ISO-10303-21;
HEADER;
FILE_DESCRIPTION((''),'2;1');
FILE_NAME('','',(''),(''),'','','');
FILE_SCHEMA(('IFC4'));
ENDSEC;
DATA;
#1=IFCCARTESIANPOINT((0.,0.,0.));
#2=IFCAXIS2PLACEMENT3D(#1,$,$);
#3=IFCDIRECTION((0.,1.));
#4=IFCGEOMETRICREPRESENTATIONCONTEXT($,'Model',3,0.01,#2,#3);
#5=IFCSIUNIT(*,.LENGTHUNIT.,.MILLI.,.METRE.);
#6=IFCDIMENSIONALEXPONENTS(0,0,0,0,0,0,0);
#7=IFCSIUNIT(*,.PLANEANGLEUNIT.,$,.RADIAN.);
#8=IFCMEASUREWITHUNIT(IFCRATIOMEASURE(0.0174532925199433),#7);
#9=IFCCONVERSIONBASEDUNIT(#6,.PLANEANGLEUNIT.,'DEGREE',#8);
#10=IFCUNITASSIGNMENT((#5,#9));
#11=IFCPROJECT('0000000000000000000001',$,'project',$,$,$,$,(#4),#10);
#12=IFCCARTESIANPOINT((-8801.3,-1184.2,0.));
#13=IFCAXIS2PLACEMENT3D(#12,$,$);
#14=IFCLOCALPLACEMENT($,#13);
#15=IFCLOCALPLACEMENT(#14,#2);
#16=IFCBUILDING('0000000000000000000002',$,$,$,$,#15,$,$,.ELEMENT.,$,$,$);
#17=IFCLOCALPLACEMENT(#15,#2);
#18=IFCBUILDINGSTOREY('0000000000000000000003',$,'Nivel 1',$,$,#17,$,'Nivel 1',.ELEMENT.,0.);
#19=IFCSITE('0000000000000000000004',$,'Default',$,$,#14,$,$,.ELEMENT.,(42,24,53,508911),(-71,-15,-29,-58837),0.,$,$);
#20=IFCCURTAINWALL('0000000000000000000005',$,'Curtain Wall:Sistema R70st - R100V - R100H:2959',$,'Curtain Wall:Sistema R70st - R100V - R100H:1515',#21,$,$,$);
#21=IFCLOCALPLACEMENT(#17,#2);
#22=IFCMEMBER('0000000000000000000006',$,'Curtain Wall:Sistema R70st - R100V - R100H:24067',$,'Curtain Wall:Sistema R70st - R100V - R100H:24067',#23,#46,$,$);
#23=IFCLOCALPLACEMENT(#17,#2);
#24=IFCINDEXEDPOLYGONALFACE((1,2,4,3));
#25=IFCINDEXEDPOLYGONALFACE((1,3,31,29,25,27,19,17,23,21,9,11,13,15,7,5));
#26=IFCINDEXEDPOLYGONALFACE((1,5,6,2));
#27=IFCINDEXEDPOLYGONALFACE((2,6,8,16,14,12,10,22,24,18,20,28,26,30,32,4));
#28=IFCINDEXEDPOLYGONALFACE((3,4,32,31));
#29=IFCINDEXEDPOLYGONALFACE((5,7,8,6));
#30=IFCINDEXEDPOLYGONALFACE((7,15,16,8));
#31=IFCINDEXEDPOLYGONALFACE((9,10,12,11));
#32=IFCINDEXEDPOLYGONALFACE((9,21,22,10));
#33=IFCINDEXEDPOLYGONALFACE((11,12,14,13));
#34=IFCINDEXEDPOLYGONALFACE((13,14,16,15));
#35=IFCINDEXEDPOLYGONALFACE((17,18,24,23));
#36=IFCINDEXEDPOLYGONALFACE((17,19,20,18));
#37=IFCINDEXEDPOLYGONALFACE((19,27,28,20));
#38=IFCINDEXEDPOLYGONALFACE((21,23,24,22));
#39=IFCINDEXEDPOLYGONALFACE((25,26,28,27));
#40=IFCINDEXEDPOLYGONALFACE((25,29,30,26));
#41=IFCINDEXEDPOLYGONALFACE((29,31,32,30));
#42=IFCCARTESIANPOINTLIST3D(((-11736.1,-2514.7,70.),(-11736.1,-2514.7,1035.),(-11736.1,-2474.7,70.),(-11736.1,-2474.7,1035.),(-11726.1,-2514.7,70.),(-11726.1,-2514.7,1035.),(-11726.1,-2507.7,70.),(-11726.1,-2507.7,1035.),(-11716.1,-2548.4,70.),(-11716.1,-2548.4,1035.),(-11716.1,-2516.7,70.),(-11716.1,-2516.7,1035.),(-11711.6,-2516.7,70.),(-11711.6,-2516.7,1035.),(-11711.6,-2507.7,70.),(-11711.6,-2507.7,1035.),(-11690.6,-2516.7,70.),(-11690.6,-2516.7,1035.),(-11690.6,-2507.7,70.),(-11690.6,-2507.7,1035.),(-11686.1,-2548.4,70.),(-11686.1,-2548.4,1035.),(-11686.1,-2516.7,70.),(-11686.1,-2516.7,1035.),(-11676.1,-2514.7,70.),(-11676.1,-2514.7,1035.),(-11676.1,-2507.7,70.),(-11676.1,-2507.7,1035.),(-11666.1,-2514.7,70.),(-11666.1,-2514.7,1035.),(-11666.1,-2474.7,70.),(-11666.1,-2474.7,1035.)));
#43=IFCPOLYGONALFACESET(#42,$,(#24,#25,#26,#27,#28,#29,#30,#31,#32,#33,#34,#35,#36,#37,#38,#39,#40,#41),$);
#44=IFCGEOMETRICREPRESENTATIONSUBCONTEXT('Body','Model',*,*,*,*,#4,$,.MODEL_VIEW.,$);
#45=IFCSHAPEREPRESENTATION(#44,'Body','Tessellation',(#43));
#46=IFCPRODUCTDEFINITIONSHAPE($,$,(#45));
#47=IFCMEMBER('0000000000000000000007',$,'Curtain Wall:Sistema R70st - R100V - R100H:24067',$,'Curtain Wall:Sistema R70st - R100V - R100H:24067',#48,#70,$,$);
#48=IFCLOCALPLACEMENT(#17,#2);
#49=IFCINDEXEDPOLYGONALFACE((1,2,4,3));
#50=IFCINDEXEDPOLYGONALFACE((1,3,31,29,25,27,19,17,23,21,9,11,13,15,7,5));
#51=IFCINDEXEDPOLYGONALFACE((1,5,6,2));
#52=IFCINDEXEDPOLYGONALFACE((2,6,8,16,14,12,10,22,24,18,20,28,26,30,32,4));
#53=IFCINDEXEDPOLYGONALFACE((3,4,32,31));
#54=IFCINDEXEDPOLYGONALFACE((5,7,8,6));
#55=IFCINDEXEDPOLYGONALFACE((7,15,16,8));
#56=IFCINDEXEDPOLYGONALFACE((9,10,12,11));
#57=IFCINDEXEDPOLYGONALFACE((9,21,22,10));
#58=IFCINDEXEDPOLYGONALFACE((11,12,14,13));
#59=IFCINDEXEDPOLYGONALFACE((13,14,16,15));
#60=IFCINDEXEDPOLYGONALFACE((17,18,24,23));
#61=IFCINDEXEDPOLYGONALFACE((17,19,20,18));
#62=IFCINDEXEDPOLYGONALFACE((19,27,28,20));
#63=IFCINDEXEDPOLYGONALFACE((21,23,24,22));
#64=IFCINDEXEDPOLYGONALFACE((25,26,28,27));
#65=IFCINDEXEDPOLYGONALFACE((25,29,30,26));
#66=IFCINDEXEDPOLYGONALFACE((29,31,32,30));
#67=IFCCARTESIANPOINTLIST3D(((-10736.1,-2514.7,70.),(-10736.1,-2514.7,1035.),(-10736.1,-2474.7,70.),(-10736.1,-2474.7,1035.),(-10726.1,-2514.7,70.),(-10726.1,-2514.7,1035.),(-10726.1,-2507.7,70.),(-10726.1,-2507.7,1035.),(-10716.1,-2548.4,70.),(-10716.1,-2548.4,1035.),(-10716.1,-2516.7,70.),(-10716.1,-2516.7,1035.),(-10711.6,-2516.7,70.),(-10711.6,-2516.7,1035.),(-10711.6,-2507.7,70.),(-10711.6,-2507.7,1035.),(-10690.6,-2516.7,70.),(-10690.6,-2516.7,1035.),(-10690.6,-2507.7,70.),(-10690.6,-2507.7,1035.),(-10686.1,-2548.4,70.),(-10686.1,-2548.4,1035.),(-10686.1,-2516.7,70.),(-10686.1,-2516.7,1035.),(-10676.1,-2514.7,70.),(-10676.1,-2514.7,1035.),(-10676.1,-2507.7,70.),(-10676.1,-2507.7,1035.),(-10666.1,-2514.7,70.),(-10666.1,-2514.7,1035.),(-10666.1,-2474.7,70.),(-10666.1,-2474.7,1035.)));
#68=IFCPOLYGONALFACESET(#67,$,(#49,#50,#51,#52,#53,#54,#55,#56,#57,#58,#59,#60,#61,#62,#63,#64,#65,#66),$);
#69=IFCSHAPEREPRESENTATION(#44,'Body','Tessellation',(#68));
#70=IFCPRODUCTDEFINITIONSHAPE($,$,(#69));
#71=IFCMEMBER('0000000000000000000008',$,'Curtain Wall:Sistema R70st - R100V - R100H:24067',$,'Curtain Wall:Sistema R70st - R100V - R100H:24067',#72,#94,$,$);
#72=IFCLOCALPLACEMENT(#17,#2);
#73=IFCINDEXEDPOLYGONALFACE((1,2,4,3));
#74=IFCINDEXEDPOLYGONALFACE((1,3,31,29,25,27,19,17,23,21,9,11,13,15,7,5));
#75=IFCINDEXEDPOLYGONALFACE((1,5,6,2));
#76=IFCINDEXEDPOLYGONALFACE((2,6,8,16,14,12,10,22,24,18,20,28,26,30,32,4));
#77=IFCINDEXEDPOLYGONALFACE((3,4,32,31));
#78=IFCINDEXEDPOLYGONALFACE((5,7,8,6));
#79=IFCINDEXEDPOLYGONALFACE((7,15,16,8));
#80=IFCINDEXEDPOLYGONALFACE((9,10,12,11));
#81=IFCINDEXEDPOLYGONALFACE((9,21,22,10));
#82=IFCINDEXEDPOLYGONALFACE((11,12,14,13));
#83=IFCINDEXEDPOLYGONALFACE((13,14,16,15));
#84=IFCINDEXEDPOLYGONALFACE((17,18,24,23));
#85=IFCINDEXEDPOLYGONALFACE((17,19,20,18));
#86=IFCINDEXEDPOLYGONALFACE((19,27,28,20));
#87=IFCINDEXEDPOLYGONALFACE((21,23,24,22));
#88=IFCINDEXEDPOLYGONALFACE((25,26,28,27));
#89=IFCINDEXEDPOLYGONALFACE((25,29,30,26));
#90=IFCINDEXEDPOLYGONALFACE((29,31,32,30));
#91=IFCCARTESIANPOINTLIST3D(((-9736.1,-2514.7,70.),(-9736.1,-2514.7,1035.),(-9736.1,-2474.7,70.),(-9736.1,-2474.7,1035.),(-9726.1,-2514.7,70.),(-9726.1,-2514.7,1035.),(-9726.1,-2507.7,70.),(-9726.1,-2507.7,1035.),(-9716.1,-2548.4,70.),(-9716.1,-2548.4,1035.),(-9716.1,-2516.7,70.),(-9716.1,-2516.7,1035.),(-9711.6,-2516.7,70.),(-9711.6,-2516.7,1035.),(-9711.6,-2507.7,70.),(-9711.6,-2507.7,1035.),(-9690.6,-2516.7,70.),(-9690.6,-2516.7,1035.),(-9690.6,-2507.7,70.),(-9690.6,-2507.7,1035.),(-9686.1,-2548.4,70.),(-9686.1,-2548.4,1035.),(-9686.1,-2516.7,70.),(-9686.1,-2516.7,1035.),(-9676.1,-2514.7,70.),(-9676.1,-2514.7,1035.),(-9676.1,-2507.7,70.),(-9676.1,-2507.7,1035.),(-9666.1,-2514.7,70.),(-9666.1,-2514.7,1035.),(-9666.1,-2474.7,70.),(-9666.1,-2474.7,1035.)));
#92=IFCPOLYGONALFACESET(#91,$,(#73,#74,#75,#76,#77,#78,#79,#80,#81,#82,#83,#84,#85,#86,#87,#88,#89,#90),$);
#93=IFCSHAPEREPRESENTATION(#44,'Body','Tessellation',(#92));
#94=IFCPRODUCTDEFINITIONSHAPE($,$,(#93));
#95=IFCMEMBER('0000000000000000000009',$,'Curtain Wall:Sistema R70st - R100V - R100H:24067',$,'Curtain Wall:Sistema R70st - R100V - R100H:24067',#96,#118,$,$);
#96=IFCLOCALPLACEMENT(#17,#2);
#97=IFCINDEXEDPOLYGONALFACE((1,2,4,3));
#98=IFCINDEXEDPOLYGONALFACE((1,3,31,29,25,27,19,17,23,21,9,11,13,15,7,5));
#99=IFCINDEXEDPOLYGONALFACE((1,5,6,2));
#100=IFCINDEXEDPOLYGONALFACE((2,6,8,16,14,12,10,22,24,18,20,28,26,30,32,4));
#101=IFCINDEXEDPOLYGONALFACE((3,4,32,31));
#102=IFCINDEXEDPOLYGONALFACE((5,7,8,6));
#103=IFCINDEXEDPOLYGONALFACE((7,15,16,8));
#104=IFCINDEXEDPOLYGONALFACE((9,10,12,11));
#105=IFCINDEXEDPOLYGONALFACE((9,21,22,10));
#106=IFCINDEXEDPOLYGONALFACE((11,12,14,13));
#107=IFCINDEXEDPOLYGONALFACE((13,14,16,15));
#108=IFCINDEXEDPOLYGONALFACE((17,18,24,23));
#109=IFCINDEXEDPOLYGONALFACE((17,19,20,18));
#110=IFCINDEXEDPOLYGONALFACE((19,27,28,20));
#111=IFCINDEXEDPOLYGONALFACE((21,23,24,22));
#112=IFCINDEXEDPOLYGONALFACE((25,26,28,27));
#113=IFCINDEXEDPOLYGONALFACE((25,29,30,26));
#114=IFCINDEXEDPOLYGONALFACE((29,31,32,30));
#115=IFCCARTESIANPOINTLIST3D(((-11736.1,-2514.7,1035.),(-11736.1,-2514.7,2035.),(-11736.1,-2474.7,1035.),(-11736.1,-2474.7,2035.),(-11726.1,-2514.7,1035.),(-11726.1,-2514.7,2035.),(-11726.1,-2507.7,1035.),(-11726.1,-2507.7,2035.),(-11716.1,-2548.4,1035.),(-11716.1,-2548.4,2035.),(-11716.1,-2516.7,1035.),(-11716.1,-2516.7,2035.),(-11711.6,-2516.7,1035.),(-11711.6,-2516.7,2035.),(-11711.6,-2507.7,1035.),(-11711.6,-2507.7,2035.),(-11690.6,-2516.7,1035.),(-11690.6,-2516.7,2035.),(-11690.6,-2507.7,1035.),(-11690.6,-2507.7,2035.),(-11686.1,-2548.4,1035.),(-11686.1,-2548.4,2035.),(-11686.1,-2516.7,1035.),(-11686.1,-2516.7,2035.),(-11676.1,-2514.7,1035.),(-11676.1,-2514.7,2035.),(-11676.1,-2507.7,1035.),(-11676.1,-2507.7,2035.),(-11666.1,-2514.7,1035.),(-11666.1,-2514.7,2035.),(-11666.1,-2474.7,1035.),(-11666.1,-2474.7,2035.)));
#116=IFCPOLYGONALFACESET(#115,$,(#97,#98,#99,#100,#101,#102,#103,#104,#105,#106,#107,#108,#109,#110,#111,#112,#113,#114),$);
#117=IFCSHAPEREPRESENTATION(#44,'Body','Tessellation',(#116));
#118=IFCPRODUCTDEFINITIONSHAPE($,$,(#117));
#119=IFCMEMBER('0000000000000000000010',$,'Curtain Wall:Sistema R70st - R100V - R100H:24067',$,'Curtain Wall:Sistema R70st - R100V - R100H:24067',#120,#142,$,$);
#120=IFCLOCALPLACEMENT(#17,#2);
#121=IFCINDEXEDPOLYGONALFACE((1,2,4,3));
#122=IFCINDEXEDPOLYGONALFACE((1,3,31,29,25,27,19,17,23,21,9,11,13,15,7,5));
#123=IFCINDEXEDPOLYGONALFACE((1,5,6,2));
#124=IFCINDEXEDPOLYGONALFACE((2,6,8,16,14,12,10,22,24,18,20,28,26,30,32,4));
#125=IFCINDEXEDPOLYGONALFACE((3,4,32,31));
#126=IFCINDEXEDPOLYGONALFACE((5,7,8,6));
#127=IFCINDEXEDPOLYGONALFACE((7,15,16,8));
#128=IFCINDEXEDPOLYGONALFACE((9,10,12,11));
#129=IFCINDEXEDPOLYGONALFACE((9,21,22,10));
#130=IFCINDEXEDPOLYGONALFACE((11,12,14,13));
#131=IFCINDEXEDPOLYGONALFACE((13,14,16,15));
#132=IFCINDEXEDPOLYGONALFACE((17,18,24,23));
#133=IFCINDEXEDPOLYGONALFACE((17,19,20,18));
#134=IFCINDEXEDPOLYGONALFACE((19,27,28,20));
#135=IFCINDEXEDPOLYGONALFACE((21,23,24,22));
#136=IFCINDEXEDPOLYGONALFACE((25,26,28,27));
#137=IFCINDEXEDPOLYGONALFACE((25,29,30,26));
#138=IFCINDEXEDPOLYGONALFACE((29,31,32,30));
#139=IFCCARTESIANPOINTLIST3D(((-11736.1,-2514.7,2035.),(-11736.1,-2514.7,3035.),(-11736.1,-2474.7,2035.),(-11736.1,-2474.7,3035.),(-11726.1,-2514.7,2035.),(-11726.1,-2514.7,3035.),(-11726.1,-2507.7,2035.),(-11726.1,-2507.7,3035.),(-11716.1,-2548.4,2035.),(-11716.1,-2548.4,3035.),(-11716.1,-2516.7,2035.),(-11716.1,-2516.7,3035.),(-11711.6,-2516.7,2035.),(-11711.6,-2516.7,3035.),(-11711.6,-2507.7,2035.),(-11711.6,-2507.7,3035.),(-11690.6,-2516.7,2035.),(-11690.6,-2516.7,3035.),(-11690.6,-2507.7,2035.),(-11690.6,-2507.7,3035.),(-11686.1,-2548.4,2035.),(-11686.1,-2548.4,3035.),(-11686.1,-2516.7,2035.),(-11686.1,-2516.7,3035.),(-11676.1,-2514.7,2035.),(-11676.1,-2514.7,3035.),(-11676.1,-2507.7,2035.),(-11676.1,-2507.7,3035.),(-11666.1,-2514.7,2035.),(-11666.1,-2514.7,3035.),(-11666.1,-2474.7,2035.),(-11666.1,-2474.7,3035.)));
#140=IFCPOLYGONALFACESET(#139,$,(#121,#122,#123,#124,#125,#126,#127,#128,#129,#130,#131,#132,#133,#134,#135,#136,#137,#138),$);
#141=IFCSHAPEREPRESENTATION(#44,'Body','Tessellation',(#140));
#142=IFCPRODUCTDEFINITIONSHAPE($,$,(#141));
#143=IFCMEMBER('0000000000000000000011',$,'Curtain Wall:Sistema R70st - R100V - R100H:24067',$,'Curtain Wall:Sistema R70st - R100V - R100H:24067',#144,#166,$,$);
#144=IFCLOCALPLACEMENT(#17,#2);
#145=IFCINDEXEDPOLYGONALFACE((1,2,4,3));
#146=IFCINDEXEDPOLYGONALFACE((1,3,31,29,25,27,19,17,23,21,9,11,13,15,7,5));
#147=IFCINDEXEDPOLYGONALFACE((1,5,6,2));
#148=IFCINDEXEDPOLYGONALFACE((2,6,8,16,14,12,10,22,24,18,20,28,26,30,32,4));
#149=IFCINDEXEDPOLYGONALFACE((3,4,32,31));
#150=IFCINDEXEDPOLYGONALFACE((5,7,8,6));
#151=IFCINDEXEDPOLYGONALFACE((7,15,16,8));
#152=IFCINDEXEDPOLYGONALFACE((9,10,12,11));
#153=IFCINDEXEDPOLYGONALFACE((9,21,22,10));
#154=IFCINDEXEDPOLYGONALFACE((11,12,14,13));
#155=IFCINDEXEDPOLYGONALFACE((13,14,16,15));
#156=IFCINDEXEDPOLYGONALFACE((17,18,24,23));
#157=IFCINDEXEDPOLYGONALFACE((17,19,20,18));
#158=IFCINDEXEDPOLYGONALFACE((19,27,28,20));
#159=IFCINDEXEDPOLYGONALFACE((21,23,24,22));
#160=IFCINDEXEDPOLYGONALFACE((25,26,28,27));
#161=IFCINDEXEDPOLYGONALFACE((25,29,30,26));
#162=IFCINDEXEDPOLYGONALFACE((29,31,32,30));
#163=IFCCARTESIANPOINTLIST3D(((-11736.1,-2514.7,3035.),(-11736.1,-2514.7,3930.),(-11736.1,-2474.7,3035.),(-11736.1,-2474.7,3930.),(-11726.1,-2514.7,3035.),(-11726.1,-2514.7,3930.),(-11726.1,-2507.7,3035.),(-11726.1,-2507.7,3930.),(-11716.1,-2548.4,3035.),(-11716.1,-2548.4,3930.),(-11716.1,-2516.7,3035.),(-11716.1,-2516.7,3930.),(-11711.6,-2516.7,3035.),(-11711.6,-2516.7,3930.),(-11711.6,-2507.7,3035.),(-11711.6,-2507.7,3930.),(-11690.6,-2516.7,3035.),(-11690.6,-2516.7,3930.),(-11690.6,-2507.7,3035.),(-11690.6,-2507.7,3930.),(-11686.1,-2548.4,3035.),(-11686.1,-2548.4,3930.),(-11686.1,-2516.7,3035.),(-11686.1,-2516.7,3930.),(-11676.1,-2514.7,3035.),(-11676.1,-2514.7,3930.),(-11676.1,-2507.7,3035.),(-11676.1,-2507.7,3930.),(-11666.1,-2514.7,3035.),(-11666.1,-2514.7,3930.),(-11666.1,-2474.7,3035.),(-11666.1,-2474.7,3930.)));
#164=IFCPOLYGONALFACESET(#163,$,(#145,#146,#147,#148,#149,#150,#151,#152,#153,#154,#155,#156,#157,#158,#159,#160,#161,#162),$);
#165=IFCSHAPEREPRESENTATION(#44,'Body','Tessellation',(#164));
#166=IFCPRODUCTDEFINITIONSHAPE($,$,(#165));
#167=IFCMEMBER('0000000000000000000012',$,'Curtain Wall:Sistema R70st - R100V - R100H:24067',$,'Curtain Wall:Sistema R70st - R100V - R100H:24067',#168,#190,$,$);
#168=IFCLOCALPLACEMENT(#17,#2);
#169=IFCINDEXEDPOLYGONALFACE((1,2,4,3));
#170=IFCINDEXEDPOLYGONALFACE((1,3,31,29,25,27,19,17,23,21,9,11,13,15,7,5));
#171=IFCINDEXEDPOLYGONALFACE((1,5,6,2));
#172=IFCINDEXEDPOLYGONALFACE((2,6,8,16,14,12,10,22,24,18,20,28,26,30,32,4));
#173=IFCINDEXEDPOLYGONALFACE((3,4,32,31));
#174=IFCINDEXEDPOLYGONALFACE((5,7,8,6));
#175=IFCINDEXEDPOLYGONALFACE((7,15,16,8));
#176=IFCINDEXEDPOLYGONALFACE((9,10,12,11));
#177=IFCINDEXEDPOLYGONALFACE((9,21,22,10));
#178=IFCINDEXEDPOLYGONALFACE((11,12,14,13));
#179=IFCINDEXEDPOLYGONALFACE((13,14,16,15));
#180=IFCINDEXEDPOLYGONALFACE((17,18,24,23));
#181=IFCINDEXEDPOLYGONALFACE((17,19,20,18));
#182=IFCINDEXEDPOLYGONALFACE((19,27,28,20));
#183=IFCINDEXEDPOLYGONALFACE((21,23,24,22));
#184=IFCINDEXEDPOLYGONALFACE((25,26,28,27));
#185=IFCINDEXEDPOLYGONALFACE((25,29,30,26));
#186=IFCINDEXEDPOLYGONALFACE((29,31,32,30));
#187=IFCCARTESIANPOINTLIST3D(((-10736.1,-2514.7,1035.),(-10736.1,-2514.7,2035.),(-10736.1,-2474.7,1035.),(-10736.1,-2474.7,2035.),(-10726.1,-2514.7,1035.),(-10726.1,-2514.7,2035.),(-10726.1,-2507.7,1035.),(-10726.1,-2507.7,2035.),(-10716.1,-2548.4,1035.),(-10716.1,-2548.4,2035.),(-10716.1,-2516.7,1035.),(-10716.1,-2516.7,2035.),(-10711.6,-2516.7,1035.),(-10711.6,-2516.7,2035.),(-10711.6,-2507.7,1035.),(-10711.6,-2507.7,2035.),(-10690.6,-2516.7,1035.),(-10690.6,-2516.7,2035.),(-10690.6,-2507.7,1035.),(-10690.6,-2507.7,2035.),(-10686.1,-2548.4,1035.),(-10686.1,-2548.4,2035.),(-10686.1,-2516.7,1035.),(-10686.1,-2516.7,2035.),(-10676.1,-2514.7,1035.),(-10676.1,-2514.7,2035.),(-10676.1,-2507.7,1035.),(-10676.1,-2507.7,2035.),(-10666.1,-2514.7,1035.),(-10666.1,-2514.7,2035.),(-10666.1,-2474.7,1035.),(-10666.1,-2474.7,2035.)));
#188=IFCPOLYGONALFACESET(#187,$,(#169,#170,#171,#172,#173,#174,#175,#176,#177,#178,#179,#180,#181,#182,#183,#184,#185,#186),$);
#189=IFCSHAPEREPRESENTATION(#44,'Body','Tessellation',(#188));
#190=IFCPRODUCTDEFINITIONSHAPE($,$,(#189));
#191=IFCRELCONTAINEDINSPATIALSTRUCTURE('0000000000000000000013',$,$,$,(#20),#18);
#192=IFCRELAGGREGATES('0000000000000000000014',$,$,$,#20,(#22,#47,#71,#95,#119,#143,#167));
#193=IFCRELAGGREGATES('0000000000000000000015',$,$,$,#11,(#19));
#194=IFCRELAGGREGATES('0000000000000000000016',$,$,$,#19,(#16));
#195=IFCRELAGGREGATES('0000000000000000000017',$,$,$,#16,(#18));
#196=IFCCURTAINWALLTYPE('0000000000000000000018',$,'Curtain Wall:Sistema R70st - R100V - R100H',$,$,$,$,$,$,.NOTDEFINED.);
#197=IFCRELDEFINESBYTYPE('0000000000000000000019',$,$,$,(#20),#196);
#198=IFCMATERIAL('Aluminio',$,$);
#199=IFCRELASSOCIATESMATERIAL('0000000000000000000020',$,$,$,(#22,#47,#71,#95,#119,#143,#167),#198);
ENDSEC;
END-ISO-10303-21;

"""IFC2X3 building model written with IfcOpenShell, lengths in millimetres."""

from ifc_helpers import new_model, entity, si_unit, converted_unit, direction, frame, origin, place, context, subcontext, project, spatial, polyline, outline, extrude, material, type_object, element, aggregate, save


model = new_model("IFC2X3")

# Units and contexts
model_context = context("Model", 3, precision=0.01, world=origin(), true_north=direction((0.0, 1.0)))
body_context = subcontext(model_context, "Body", "Model", "MODEL_VIEW")
ifc_project = project(units=[si_unit("LENGTHUNIT", "METRE", prefix="MILLI"), converted_unit("PLANEANGLEUNIT", "DEGREE", entity("IfcRatioMeasure", 0.0174532925199433), si_unit("PLANEANGLEUNIT", "RADIAN"), dimensions=[0, 0, 0, 0, 0, 0, 0])], contexts=[model_context])

# Site, building, storey
site_placement = place(None, frame((-8801.3, -1184.2, 0.0)))
site = spatial("IfcSite", under=ifc_project, at=site_placement, Name="Default", CompositionType="ELEMENT", RefLatitude=(42, 24, 53, 508911), RefLongitude=(-71, -15, -29, -58837), RefElevation=0.0)
building_placement = place(site_placement, origin())
building = spatial("IfcBuilding", under=site, at=building_placement, CompositionType="ELEMENT")
storey_placement = place(building_placement, origin())
storey = spatial("IfcBuildingStorey", under=building, at=storey_placement, Name="Nivel 1", LongName="Nivel 1", CompositionType="ELEMENT", Elevation=0.0)

# Curtain wall, members
curtain_wall_type = type_object("IfcCurtainWallType", Name="Curtain Wall:Sistema R70st - R100V - R100H", PredefinedType="NOTDEFINED")
curtain_wall_placement = place(storey_placement, origin())
curtain_wall = element("IfcCurtainWall", 1, at=curtain_wall_placement, inside=storey, type_object=curtain_wall_type, Name="Curtain Wall:Sistema R70st - R100V - R100H:2959", ObjectType="Curtain Wall:Sistema R70st - R100V - R100H:1515")
ifc_material = material(Name="Aluminio")
member_1_placement = place(curtain_wall_placement, origin())
member_1 = element("IfcMember", 2, at=member_1_placement, material=ifc_material, Name="Curtain Wall:Sistema R70st - R100V - R100H:24067", ObjectType="Curtain Wall:Sistema R70st - R100V - R100H:24067", context=body_context, shape_type="SweptSolid", body=[
    extrude(outline(polyline([(-35.0, -38.0), (35.0, -38.0), (35.0, 2.0), (25.0, 2.0), (25.0, -5.0), (10.5, -5.0), (10.5, 4.0), (15.0, 4.0), (15.0, 35.7), (-15.0, 35.7), (-15.0, 4.0), (-10.5, 4.0), (-10.5, -5.0), (-25.0, -5.0), (-25.0, 2.0), (-35.0, 2.0), (-35.0, -38.0)])), frame((-11701.1, -2512.7, 70.0), z_axis=(0.0, 0.0, 1.0), x_axis=(-1.0, 0.0, 0.0)), (0.0, 0.0, 1.0), 965.0),
])
member_2_placement = place(curtain_wall_placement, origin())
member_2 = element("IfcMember", 3, at=member_2_placement, material=ifc_material, Name="Curtain Wall:Sistema R70st - R100V - R100H:24067", ObjectType="Curtain Wall:Sistema R70st - R100V - R100H:24067", context=body_context, shape_type="SweptSolid", body=[
    extrude(outline(polyline([(-35.0, -38.0), (35.0, -38.0), (35.0, 2.0), (25.0, 2.0), (25.0, -5.0), (10.5, -5.0), (10.5, 4.0), (15.0, 4.0), (15.0, 35.7), (-15.0, 35.7), (-15.0, 4.0), (-10.5, 4.0), (-10.5, -5.0), (-25.0, -5.0), (-25.0, 2.0), (-35.0, 2.0), (-35.0, -38.0)])), frame((-10701.1, -2512.7, 70.0), z_axis=(0.0, 0.0, 1.0), x_axis=(-1.0, 0.0, 0.0)), (0.0, 0.0, 1.0), 965.0),
])
member_3_placement = place(curtain_wall_placement, origin())
member_3 = element("IfcMember", 4, at=member_3_placement, material=ifc_material, Name="Curtain Wall:Sistema R70st - R100V - R100H:24067", ObjectType="Curtain Wall:Sistema R70st - R100V - R100H:24067", context=body_context, shape_type="SweptSolid", body=[
    extrude(outline(polyline([(-35.0, -38.0), (35.0, -38.0), (35.0, 2.0), (25.0, 2.0), (25.0, -5.0), (10.5, -5.0), (10.5, 4.0), (15.0, 4.0), (15.0, 35.7), (-15.0, 35.7), (-15.0, 4.0), (-10.5, 4.0), (-10.5, -5.0), (-25.0, -5.0), (-25.0, 2.0), (-35.0, 2.0), (-35.0, -38.0)])), frame((-9701.1, -2512.7, 70.0), z_axis=(0.0, 0.0, 1.0), x_axis=(-1.0, 0.0, 0.0)), (0.0, 0.0, 1.0), 965.0),
])
member_4_placement = place(curtain_wall_placement, origin())
member_4 = element("IfcMember", 5, at=member_4_placement, material=ifc_material, Name="Curtain Wall:Sistema R70st - R100V - R100H:24067", ObjectType="Curtain Wall:Sistema R70st - R100V - R100H:24067", context=body_context, shape_type="SweptSolid", body=[
    extrude(outline(polyline([(-35.0, -38.0), (35.0, -38.0), (35.0, 2.0), (25.0, 2.0), (25.0, -5.0), (10.5, -5.0), (10.5, 4.0), (15.0, 4.0), (15.0, 35.7), (-15.0, 35.7), (-15.0, 4.0), (-10.5, 4.0), (-10.5, -5.0), (-25.0, -5.0), (-25.0, 2.0), (-35.0, 2.0), (-35.0, -38.0)])), frame((-11701.1, -2512.7, 1035.0), z_axis=(0.0, 0.0, 1.0), x_axis=(-1.0, 0.0, 0.0)), (0.0, 0.0, 1.0), 1000.0),
])
member_5_placement = place(curtain_wall_placement, origin())
member_5 = element("IfcMember", 6, at=member_5_placement, material=ifc_material, Name="Curtain Wall:Sistema R70st - R100V - R100H:24067", ObjectType="Curtain Wall:Sistema R70st - R100V - R100H:24067", context=body_context, shape_type="SweptSolid", body=[
    extrude(outline(polyline([(-35.0, -38.0), (35.0, -38.0), (35.0, 2.0), (25.0, 2.0), (25.0, -5.0), (10.5, -5.0), (10.5, 4.0), (15.0, 4.0), (15.0, 35.7), (-15.0, 35.7), (-15.0, 4.0), (-10.5, 4.0), (-10.5, -5.0), (-25.0, -5.0), (-25.0, 2.0), (-35.0, 2.0), (-35.0, -38.0)])), frame((-11701.1, -2512.7, 2035.0), z_axis=(0.0, 0.0, 1.0), x_axis=(-1.0, 0.0, 0.0)), (0.0, 0.0, 1.0), 1000.0),
])
member_6_placement = place(curtain_wall_placement, origin())
member_6 = element("IfcMember", 7, at=member_6_placement, material=ifc_material, Name="Curtain Wall:Sistema R70st - R100V - R100H:24067", ObjectType="Curtain Wall:Sistema R70st - R100V - R100H:24067", context=body_context, shape_type="SweptSolid", body=[
    extrude(outline(polyline([(-35.0, -38.0), (35.0, -38.0), (35.0, 2.0), (25.0, 2.0), (25.0, -5.0), (10.5, -5.0), (10.5, 4.0), (15.0, 4.0), (15.0, 35.7), (-15.0, 35.7), (-15.0, 4.0), (-10.5, 4.0), (-10.5, -5.0), (-25.0, -5.0), (-25.0, 2.0), (-35.0, 2.0), (-35.0, -38.0)])), frame((-11701.1, -2512.7, 3035.0), z_axis=(0.0, 0.0, 1.0), x_axis=(-1.0, 0.0, 0.0)), (0.0, 0.0, 1.0), 895.0),
])
member_7_placement = place(curtain_wall_placement, origin())
member_7 = element("IfcMember", 8, at=member_7_placement, material=ifc_material, Name="Curtain Wall:Sistema R70st - R100V - R100H:24067", ObjectType="Curtain Wall:Sistema R70st - R100V - R100H:24067", context=body_context, shape_type="SweptSolid", body=[
    extrude(outline(polyline([(-35.0, -38.0), (35.0, -38.0), (35.0, 2.0), (25.0, 2.0), (25.0, -5.0), (10.5, -5.0), (10.5, 4.0), (15.0, 4.0), (15.0, 35.7), (-15.0, 35.7), (-15.0, 4.0), (-10.5, 4.0), (-10.5, -5.0), (-25.0, -5.0), (-25.0, 2.0), (-35.0, 2.0), (-35.0, -38.0)])), frame((-10701.1, -2512.7, 1035.0), z_axis=(0.0, 0.0, 1.0), x_axis=(-1.0, 0.0, 0.0)), (0.0, 0.0, 1.0), 1000.0),
])
aggregate(curtain_wall, [member_1, member_2, member_3, member_4, member_5, member_6, member_7])

save(model, "model.ifc")
